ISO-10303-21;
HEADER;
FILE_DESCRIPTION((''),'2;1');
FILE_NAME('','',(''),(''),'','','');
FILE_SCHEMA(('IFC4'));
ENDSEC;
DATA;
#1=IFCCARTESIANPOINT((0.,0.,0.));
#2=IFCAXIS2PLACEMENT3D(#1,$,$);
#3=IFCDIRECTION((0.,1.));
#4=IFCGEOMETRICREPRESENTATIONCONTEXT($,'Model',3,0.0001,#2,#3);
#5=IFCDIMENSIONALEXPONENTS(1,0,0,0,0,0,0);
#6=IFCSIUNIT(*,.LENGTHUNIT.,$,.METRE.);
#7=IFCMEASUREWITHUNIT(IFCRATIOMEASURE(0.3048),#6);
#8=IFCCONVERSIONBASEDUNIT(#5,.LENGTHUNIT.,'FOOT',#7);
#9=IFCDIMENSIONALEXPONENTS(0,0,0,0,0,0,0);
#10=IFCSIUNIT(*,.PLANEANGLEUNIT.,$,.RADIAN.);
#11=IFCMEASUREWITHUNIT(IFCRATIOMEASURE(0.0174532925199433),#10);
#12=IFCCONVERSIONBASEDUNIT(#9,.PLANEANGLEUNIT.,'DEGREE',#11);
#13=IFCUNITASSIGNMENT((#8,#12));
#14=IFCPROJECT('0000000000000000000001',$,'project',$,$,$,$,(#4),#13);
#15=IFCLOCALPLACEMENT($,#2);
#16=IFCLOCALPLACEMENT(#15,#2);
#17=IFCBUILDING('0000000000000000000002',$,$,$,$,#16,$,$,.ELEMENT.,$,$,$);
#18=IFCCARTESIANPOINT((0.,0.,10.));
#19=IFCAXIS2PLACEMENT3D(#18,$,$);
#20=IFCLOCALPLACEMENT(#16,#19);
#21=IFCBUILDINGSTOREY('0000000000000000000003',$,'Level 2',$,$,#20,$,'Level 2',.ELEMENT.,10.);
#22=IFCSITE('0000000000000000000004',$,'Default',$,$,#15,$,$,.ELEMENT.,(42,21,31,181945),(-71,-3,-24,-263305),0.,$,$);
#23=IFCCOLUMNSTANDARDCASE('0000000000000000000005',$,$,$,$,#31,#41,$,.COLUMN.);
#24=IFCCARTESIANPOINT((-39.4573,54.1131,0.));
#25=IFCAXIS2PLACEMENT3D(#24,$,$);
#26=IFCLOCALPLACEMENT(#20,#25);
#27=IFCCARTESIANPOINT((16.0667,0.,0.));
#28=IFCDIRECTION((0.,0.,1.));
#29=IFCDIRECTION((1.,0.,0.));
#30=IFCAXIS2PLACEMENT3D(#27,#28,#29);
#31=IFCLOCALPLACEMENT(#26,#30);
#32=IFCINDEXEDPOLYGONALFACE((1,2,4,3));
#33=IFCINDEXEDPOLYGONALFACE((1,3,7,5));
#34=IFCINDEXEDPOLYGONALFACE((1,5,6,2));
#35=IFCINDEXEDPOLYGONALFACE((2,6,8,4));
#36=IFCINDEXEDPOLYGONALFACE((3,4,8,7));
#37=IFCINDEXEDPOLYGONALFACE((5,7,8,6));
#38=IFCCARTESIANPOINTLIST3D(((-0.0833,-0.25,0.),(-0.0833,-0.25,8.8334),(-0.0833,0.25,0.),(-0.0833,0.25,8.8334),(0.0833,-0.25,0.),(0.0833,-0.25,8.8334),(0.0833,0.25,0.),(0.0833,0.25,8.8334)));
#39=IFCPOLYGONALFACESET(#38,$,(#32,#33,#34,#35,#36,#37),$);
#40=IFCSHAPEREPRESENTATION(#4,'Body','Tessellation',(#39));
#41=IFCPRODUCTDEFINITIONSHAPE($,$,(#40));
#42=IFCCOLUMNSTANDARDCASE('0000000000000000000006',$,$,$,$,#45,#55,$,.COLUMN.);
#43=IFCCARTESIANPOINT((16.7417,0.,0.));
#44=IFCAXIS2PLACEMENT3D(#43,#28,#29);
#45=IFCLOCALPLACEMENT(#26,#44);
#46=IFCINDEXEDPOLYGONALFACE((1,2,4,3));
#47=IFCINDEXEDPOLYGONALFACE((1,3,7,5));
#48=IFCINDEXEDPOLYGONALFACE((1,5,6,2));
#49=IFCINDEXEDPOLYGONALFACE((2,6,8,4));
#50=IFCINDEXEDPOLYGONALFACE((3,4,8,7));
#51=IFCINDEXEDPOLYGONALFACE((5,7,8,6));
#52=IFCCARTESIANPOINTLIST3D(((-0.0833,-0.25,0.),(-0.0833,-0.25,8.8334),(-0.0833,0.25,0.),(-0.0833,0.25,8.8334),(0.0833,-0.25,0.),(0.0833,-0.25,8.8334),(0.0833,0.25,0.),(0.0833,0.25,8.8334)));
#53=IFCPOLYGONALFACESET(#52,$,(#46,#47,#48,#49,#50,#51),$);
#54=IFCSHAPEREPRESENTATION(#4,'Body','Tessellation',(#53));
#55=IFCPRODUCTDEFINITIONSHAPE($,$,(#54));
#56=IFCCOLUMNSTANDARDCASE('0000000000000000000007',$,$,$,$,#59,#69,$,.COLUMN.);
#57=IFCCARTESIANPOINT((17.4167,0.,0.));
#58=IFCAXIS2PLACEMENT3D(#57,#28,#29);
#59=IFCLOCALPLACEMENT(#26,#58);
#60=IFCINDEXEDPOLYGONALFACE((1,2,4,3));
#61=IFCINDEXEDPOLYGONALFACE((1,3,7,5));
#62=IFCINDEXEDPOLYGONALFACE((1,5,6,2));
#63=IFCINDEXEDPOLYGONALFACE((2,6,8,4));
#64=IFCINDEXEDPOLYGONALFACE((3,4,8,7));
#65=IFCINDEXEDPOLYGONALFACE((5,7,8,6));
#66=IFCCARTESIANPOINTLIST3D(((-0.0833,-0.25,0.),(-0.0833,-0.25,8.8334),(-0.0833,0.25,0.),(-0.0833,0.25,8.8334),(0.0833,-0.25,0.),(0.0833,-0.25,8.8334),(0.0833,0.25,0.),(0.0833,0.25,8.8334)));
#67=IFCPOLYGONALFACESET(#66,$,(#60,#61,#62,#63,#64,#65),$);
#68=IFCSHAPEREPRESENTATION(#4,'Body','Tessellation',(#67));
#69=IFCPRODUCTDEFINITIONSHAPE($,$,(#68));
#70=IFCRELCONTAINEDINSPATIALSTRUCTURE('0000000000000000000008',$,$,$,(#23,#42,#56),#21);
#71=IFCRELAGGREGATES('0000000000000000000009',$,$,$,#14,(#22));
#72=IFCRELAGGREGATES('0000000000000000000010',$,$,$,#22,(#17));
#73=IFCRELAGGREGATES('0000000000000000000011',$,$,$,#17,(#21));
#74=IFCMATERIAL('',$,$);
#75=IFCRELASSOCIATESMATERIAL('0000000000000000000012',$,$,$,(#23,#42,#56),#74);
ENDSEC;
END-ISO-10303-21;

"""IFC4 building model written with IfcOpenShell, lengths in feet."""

from ifc_helpers import new_model, entity, si_unit, converted_unit, direction, frame, origin, place, context, project, spatial, rectangle, extrude, material, element, save


model = new_model("IFC4")

# Units and contexts
model_context = context("Model", 3, precision=0.0001, world=origin(), true_north=direction((0.0, 1.0)))
ifc_project = project(units=[converted_unit("LENGTHUNIT", "FOOT", entity("IfcRatioMeasure", 0.3048), si_unit("LENGTHUNIT", "METRE"), dimensions=[1, 0, 0, 0, 0, 0, 0]), converted_unit("PLANEANGLEUNIT", "DEGREE", entity("IfcRatioMeasure", 0.0174532925199433), si_unit("PLANEANGLEUNIT", "RADIAN"), dimensions=[0, 0, 0, 0, 0, 0, 0])], contexts=[model_context])

# Site, building, storey
site_placement = place(None, origin())
site = spatial("IfcSite", under=ifc_project, at=site_placement, Name="Default", CompositionType="ELEMENT", RefLatitude=(42, 21, 31, 181945), RefLongitude=(-71, -3, -24, -263305), RefElevation=0.0)
building_placement = place(site_placement, origin())
building = spatial("IfcBuilding", under=site, at=building_placement, CompositionType="ELEMENT")
storey_placement = place(building_placement, frame((0.0, 0.0, 10.0)))
storey = spatial("IfcBuildingStorey", under=building, at=storey_placement, Name="Level 2", LongName="Level 2", CompositionType="ELEMENT", Elevation=10.0)

# Columns
ifc_material_1 = material(Name="")
placement_1 = place(storey_placement, frame((-39.4573, 54.1131, 0.0)))
for number, where, z_axis, x_axis in (
    (1, (16.0667, 0.0, 0.0), (0.0, 0.0, 1.0), (1.0, 0.0, 0.0)),
    (2, (16.7417, 0.0, 0.0), (0.0, 0.0, 1.0), (1.0, 0.0, 0.0)),
    (3, (17.4167, 0.0, 0.0), (0.0, 0.0, 1.0), (1.0, 0.0, 0.0)),
):
    element("IfcColumnStandardCase", number, at=place(placement_1, frame(where, z_axis=z_axis, x_axis=x_axis)), inside=storey, material=ifc_material_1, PredefinedType="COLUMN", context=model_context, shape_type="SweptSolid", body=[
        extrude(rectangle(XDim=0.1667, YDim=0.5), origin(), (0.0, 0.0, 1.0), 8.8334),
    ])

save(model, "model.ifc")
